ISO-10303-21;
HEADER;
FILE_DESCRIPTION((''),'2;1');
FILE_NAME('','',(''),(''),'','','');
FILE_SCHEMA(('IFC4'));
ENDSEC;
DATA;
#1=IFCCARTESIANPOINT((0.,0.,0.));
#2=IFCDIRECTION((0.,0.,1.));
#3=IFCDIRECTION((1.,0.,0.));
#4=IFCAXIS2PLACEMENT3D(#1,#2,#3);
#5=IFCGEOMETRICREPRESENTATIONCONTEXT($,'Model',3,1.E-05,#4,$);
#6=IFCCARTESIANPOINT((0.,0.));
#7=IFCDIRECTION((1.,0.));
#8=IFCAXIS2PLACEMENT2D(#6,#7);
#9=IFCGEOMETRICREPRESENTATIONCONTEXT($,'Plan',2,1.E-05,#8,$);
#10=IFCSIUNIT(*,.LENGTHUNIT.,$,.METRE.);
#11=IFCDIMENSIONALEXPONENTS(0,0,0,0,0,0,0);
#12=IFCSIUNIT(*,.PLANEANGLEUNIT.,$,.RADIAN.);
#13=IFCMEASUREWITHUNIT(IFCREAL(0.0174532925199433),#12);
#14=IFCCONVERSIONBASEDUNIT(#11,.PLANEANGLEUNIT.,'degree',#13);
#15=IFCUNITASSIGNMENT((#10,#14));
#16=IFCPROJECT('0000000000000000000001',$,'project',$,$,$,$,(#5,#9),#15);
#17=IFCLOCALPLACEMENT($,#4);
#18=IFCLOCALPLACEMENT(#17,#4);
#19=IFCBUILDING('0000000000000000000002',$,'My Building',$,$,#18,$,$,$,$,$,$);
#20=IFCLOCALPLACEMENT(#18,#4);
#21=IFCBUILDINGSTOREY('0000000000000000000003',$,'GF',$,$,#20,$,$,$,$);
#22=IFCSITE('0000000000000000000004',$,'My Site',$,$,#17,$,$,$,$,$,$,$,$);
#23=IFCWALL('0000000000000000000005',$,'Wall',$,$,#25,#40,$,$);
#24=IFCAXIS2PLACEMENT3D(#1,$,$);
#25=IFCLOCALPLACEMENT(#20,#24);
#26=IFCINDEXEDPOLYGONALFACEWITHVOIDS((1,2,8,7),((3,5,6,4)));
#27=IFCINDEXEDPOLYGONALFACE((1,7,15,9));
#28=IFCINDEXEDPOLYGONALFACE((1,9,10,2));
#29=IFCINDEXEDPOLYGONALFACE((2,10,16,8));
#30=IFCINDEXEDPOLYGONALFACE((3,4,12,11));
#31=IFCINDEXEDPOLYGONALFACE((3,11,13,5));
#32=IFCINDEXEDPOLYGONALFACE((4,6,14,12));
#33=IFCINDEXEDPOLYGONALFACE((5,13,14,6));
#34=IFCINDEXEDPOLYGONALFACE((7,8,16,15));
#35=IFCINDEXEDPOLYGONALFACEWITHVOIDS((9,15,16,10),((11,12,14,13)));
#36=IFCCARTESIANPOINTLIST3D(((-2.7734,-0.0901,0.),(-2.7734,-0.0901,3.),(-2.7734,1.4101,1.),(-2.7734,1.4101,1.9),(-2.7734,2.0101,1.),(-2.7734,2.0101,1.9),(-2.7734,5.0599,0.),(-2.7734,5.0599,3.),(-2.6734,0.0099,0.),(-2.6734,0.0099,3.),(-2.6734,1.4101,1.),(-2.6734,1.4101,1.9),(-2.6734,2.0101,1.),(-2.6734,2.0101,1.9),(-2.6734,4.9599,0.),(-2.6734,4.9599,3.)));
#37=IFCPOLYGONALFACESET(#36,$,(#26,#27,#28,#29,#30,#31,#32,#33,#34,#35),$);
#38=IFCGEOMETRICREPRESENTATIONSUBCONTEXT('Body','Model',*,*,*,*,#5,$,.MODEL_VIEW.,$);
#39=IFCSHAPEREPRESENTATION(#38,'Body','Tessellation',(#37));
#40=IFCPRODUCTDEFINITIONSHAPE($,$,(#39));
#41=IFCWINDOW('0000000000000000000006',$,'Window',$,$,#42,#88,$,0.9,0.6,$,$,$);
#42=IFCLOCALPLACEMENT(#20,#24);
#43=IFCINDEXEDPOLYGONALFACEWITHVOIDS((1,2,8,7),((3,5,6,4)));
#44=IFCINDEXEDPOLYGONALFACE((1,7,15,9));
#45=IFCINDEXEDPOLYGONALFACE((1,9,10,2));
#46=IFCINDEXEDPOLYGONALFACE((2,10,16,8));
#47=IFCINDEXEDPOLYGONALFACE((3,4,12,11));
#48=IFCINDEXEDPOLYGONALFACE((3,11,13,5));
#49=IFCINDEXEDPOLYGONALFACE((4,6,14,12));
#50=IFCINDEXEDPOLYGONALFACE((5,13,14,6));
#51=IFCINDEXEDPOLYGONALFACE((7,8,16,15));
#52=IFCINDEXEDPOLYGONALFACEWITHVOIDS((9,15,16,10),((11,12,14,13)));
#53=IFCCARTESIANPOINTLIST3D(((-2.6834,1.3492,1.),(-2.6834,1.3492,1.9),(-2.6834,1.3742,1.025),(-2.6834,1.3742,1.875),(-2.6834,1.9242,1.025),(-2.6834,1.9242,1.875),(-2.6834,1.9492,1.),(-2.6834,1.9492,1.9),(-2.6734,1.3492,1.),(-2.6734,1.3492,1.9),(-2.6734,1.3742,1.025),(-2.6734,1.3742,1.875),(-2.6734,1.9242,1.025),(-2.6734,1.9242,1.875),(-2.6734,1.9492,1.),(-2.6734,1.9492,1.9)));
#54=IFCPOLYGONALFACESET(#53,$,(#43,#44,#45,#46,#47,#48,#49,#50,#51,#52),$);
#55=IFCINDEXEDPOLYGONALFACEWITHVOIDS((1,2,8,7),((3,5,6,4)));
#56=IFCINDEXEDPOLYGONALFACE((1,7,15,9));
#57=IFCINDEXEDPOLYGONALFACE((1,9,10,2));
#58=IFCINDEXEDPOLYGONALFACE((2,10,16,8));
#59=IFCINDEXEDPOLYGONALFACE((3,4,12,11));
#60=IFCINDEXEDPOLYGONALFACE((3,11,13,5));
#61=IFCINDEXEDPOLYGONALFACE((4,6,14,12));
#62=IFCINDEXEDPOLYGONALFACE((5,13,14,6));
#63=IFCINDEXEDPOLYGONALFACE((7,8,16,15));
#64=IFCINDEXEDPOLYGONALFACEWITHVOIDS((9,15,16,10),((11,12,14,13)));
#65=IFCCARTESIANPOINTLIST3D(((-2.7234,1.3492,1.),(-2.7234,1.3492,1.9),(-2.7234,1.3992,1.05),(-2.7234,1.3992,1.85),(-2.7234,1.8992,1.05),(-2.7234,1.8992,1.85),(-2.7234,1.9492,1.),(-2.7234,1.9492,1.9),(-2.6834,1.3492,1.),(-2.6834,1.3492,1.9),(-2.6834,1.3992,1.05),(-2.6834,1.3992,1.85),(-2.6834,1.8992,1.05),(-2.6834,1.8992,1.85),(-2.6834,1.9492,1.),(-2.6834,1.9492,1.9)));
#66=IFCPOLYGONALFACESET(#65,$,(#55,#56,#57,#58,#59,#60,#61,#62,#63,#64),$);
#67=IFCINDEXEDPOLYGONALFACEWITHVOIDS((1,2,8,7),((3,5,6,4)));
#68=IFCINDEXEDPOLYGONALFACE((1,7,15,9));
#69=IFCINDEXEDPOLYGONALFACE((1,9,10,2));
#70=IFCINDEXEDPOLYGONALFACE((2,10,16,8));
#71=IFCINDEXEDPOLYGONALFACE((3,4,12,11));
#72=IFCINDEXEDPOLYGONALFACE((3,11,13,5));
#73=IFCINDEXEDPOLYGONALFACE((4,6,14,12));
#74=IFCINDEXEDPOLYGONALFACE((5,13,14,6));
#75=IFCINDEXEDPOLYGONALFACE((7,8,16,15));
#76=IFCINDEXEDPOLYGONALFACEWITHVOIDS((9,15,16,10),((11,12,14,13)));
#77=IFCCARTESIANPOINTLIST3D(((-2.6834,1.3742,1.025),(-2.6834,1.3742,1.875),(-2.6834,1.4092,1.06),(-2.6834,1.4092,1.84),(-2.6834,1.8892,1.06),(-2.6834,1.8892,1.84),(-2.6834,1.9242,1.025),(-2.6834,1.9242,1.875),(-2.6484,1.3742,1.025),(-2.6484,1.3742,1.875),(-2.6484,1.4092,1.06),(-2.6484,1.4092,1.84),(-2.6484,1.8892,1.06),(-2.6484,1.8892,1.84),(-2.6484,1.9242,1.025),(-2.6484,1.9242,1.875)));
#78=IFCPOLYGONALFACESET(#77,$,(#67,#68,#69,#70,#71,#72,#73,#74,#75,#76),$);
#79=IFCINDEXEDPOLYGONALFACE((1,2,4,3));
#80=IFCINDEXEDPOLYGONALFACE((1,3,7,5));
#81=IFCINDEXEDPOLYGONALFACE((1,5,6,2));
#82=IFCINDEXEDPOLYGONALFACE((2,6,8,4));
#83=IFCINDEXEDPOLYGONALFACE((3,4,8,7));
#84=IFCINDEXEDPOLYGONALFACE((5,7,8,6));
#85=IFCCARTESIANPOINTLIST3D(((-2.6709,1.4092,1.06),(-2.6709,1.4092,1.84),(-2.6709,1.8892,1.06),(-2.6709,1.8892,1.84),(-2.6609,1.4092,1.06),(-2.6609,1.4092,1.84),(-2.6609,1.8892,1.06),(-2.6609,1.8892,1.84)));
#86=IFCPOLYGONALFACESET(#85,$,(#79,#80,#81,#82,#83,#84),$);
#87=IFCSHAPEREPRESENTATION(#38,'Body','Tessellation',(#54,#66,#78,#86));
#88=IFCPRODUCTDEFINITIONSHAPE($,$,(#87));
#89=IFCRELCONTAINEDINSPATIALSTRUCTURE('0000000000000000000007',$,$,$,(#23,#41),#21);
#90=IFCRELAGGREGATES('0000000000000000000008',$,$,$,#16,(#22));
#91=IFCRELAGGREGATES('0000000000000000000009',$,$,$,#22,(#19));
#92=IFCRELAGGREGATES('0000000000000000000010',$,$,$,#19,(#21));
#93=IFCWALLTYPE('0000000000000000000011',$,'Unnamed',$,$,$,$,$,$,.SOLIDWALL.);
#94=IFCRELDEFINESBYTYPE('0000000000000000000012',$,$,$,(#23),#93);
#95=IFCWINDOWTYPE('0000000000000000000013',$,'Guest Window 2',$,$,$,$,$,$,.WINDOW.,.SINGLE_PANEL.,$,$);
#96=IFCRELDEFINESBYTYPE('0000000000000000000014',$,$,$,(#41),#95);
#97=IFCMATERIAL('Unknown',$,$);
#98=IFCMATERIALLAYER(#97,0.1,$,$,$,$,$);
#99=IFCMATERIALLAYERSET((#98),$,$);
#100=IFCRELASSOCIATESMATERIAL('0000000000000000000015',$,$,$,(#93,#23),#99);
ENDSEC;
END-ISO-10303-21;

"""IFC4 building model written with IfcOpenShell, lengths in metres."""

from ifc_helpers import new_model, entity, si_unit, converted_unit, frame, origin_with_axes, origin_2d_with_axis, place, context, subcontext, project, spatial, line, indexed_curve, outline, extrude, shape, source, transform, mapped, material, layer, layer_set, layer_usage, type_object, type_shapes, element, fill, save


model = new_model("IFC4")

# Units and contexts
model_context = context("Model", 3, precision=1e-05, world=origin_with_axes())
plan_context = context("Plan", 2, precision=1e-05, world=origin_2d_with_axis())
body_context_1 = subcontext(model_context, "Body", "Model", "MODEL_VIEW")
body_context_2 = subcontext(plan_context, "Body", "Plan", "PLAN_VIEW")
ifc_project = project(units=[si_unit("LENGTHUNIT", "METRE"), converted_unit("PLANEANGLEUNIT", "degree", entity("IfcReal", 0.0174532925199433), si_unit("PLANEANGLEUNIT", "RADIAN"), dimensions=[0, 0, 0, 0, 0, 0, 0])], contexts=[model_context, plan_context])

# Site, building, storey
site_placement = place(None, origin_with_axes())
site = spatial("IfcSite", under=ifc_project, at=site_placement, Name="My Site")
building_placement = place(site_placement, origin_with_axes())
building = spatial("IfcBuilding", under=site, at=building_placement, Name="My Building")
storey_placement = place(building_placement, origin_with_axes())
storey = spatial("IfcBuildingStorey", under=building, at=storey_placement, Name="GF")

# Shared definitions
ifc_material_1 = material(Name="Unknown")

# Shared definitions
ifc_layer_1 = layer(ifc_material_1, 0.1)
ifc_layer_set_1 = layer_set([ifc_layer_1])
wall_type = type_object("IfcWallType", Name="Unnamed", PredefinedType="SOLIDWALL", material=ifc_layer_set_1)

# Wall, opening, window
ifc_layer_usage_1 = layer_usage(ifc_layer_set_1, "AXIS2", "POSITIVE", 0.0)
wall_1_placement = place(storey_placement, frame((-2.7734, 5.0599, 0.0), z_axis=(0.0, 0.0, 1.0), x_axis=(0.0, -1.0, 0.0)))
wall_1 = element("IfcWall", 1, at=wall_1_placement, inside=storey, type_object=wall_type, material=ifc_layer_usage_1, Name="Wall", context=body_context_1, shape_type="SweptSolid", body=[
    extrude(outline(indexed_curve([(0.0, 0.0), (0.1, 0.1), (5.05, 0.1), (5.15, 0.0)], segments=[line(1, 2, 3, 4, 1)])), origin_with_axes(), (0.0, 0.0, 1.0), 3.0),
])
shared_shape_1 = source(origin_with_axes(), body_context_1, "Body", "SweptSolid", [
    extrude(outline(indexed_curve([(0.0, 0.0), (0.6, 0.0), (0.6, 0.9), (0.0, 0.9)], segments=[line(1, 2, 3, 4, 1)])), frame((0.0, -0.6, 0.0), z_axis=(0.0, -1.0, 0.0), x_axis=(1.0, 0.0, 0.0)), (0.0, 0.0, -1.0), 1.2),
])
opening_1_placement = place(wall_1_placement, frame((3.0498, 0.0, 1.0), z_axis=(0.0, 0.0, 1.0), x_axis=(1.0, 0.0, 0.0)))
opening_1 = element("IfcOpeningElement", 2, at=opening_1_placement, cuts=wall_1, PredefinedType="OPENING", context=body_context_1, shape_type="MappedRepresentation", body=[
    mapped(shared_shape_1, transform((0.0, 0.0, 0.0), x_axis=(1.0, 0.0, 0.0), y_axis=(0.0, 1.0, 0.0), z_axis=(0.0, 0.0, 1.0), scale=1.0)),
])
window_type_1 = type_object("IfcWindowType", Name="Guest Window 2", PartitioningType="SINGLE_PANEL", PredefinedType="WINDOW")
shared_shape_2 = source(origin_with_axes(), body_context_1, "Body", "SweptSolid", [
    extrude(outline(indexed_curve([(0.0, 0.0), (0.6, 0.0), (0.6, 0.9), (0.0, 0.9)], segments=[line(1, 2, 3, 4, 1)]), holes=[indexed_curve([(0.025, 0.025), (0.575, 0.025), (0.575, 0.875), (0.025, 0.875)], segments=[line(1, 2, 3, 4, 1)])]), frame((0.0, 0.09, 0.0), z_axis=(0.0, -1.0, 0.0), x_axis=(1.0, 0.0, 0.0)), (0.0, 0.0, -1.0), 0.01),
    extrude(outline(indexed_curve([(0.0, 0.0), (0.6, 0.0), (0.6, 0.9), (0.0, 0.9)], segments=[line(1, 2, 3, 4, 1)]), holes=[indexed_curve([(0.05, 0.05), (0.55, 0.05), (0.55, 0.85), (0.05, 0.85)], segments=[line(1, 2, 3, 4, 1)])]), frame((0.0, 0.05, 0.0), z_axis=(0.0, -1.0, 0.0), x_axis=(1.0, 0.0, 0.0)), (0.0, 0.0, -1.0), 0.04),
    extrude(outline(indexed_curve([(0.0, 0.0), (0.55, 0.0), (0.55, 0.85), (0.0, 0.85)], segments=[line(1, 2, 3, 4, 1)]), holes=[indexed_curve([(0.035, 0.035), (0.515, 0.035), (0.515, 0.815), (0.035, 0.815)], segments=[line(1, 2, 3, 4, 1)])]), frame((0.025, 0.09, 0.025), z_axis=(0.0, -1.0, 0.0), x_axis=(1.0, 0.0, 0.0)), (0.0, 0.0, -1.0), 0.035),
    extrude(outline(indexed_curve([(0.035, 0.035), (0.515, 0.035), (0.515, 0.815), (0.035, 0.815)], segments=[line(1, 2, 3, 4, 1)])), frame((0.025, 0.1025, 0.025), z_axis=(0.0, -1.0, 0.0), x_axis=(1.0, 0.0, 0.0)), (0.0, 0.0, -1.0), 0.01),
])
shared_shape_3 = source(origin_with_axes(), body_context_2, "Body", "Curve2D", [
    entity("IfcIndexedPolyCurve", entity("IfcCartesianPointList2D", [[0.05, 0.05], [0.55, 0.05]])),
    entity("IfcIndexedPolyCurve", entity("IfcCartesianPointList2D", [[0.0, 0.1], [0.025, 0.1], [0.025, 0.09], [0.05, 0.09], [0.05, 0.05], [0.0, 0.05]]), [entity("IfcLineIndex", [1, 2, 3, 4, 5, 6, 1])]),
    entity("IfcIndexedPolyCurve", entity("IfcCartesianPointList2D", [[0.6, 0.1], [0.575, 0.1], [0.575, 0.09], [0.55, 0.09], [0.55, 0.05], [0.6, 0.05]]), [entity("IfcLineIndex", [1, 2, 3, 4, 5, 6, 1])]),
    entity("IfcIndexedPolyCurve", entity("IfcCartesianPointList2D", [[0.025, 0.09], [0.06, 0.09], [0.06, 0.125], [0.025, 0.125]]), [entity("IfcLineIndex", [1, 2, 3, 4, 1])]),
    entity("IfcIndexedPolyCurve", entity("IfcCartesianPointList2D", [[0.575, 0.09], [0.54, 0.09], [0.54, 0.125], [0.575, 0.125]]), [entity("IfcLineIndex", [1, 2, 3, 4, 1])]),
    entity("IfcIndexedPolyCurve", entity("IfcCartesianPointList2D", [[0.06, 0.09], [0.54, 0.09]])),
    entity("IfcIndexedPolyCurve", entity("IfcCartesianPointList2D", [[0.06, 0.125], [0.54, 0.125]])),
    entity("IfcIndexedPolyCurve", entity("IfcCartesianPointList2D", [[0.06, 0.1075], [0.54, 0.1075]])),
])
type_shapes(window_type_1, [shared_shape_2, shared_shape_3])
window_1_placement = place(opening_1_placement, frame((0.061, 0.0, 0.0), z_axis=(0.0, 0.0, 1.0), x_axis=(1.0, 0.0, 0.0)))
window_1 = element("IfcWindow", 3, at=window_1_placement, inside=storey, type_object=window_type_1, Name="Window", OverallHeight=0.9, OverallWidth=0.6, shapes=[
    shape(body_context_1, "Body", "MappedRepresentation", [mapped(shared_shape_2, transform((0.0, 0.0, 0.0), x_axis=(1.0, 0.0, 0.0), y_axis=(0.0, 1.0, 0.0), z_axis=(0.0, 0.0, 1.0), scale=1.0))]),
    shape(body_context_2, "Body", "MappedRepresentation", [mapped(shared_shape_3, transform((0.0, 0.0, 0.0), x_axis=(1.0, 0.0, 0.0), y_axis=(0.0, 1.0, 0.0), z_axis=(0.0, 0.0, 1.0), scale=1.0))]),
])
fill(opening_1, window_1)

save(model, "model.ifc")
